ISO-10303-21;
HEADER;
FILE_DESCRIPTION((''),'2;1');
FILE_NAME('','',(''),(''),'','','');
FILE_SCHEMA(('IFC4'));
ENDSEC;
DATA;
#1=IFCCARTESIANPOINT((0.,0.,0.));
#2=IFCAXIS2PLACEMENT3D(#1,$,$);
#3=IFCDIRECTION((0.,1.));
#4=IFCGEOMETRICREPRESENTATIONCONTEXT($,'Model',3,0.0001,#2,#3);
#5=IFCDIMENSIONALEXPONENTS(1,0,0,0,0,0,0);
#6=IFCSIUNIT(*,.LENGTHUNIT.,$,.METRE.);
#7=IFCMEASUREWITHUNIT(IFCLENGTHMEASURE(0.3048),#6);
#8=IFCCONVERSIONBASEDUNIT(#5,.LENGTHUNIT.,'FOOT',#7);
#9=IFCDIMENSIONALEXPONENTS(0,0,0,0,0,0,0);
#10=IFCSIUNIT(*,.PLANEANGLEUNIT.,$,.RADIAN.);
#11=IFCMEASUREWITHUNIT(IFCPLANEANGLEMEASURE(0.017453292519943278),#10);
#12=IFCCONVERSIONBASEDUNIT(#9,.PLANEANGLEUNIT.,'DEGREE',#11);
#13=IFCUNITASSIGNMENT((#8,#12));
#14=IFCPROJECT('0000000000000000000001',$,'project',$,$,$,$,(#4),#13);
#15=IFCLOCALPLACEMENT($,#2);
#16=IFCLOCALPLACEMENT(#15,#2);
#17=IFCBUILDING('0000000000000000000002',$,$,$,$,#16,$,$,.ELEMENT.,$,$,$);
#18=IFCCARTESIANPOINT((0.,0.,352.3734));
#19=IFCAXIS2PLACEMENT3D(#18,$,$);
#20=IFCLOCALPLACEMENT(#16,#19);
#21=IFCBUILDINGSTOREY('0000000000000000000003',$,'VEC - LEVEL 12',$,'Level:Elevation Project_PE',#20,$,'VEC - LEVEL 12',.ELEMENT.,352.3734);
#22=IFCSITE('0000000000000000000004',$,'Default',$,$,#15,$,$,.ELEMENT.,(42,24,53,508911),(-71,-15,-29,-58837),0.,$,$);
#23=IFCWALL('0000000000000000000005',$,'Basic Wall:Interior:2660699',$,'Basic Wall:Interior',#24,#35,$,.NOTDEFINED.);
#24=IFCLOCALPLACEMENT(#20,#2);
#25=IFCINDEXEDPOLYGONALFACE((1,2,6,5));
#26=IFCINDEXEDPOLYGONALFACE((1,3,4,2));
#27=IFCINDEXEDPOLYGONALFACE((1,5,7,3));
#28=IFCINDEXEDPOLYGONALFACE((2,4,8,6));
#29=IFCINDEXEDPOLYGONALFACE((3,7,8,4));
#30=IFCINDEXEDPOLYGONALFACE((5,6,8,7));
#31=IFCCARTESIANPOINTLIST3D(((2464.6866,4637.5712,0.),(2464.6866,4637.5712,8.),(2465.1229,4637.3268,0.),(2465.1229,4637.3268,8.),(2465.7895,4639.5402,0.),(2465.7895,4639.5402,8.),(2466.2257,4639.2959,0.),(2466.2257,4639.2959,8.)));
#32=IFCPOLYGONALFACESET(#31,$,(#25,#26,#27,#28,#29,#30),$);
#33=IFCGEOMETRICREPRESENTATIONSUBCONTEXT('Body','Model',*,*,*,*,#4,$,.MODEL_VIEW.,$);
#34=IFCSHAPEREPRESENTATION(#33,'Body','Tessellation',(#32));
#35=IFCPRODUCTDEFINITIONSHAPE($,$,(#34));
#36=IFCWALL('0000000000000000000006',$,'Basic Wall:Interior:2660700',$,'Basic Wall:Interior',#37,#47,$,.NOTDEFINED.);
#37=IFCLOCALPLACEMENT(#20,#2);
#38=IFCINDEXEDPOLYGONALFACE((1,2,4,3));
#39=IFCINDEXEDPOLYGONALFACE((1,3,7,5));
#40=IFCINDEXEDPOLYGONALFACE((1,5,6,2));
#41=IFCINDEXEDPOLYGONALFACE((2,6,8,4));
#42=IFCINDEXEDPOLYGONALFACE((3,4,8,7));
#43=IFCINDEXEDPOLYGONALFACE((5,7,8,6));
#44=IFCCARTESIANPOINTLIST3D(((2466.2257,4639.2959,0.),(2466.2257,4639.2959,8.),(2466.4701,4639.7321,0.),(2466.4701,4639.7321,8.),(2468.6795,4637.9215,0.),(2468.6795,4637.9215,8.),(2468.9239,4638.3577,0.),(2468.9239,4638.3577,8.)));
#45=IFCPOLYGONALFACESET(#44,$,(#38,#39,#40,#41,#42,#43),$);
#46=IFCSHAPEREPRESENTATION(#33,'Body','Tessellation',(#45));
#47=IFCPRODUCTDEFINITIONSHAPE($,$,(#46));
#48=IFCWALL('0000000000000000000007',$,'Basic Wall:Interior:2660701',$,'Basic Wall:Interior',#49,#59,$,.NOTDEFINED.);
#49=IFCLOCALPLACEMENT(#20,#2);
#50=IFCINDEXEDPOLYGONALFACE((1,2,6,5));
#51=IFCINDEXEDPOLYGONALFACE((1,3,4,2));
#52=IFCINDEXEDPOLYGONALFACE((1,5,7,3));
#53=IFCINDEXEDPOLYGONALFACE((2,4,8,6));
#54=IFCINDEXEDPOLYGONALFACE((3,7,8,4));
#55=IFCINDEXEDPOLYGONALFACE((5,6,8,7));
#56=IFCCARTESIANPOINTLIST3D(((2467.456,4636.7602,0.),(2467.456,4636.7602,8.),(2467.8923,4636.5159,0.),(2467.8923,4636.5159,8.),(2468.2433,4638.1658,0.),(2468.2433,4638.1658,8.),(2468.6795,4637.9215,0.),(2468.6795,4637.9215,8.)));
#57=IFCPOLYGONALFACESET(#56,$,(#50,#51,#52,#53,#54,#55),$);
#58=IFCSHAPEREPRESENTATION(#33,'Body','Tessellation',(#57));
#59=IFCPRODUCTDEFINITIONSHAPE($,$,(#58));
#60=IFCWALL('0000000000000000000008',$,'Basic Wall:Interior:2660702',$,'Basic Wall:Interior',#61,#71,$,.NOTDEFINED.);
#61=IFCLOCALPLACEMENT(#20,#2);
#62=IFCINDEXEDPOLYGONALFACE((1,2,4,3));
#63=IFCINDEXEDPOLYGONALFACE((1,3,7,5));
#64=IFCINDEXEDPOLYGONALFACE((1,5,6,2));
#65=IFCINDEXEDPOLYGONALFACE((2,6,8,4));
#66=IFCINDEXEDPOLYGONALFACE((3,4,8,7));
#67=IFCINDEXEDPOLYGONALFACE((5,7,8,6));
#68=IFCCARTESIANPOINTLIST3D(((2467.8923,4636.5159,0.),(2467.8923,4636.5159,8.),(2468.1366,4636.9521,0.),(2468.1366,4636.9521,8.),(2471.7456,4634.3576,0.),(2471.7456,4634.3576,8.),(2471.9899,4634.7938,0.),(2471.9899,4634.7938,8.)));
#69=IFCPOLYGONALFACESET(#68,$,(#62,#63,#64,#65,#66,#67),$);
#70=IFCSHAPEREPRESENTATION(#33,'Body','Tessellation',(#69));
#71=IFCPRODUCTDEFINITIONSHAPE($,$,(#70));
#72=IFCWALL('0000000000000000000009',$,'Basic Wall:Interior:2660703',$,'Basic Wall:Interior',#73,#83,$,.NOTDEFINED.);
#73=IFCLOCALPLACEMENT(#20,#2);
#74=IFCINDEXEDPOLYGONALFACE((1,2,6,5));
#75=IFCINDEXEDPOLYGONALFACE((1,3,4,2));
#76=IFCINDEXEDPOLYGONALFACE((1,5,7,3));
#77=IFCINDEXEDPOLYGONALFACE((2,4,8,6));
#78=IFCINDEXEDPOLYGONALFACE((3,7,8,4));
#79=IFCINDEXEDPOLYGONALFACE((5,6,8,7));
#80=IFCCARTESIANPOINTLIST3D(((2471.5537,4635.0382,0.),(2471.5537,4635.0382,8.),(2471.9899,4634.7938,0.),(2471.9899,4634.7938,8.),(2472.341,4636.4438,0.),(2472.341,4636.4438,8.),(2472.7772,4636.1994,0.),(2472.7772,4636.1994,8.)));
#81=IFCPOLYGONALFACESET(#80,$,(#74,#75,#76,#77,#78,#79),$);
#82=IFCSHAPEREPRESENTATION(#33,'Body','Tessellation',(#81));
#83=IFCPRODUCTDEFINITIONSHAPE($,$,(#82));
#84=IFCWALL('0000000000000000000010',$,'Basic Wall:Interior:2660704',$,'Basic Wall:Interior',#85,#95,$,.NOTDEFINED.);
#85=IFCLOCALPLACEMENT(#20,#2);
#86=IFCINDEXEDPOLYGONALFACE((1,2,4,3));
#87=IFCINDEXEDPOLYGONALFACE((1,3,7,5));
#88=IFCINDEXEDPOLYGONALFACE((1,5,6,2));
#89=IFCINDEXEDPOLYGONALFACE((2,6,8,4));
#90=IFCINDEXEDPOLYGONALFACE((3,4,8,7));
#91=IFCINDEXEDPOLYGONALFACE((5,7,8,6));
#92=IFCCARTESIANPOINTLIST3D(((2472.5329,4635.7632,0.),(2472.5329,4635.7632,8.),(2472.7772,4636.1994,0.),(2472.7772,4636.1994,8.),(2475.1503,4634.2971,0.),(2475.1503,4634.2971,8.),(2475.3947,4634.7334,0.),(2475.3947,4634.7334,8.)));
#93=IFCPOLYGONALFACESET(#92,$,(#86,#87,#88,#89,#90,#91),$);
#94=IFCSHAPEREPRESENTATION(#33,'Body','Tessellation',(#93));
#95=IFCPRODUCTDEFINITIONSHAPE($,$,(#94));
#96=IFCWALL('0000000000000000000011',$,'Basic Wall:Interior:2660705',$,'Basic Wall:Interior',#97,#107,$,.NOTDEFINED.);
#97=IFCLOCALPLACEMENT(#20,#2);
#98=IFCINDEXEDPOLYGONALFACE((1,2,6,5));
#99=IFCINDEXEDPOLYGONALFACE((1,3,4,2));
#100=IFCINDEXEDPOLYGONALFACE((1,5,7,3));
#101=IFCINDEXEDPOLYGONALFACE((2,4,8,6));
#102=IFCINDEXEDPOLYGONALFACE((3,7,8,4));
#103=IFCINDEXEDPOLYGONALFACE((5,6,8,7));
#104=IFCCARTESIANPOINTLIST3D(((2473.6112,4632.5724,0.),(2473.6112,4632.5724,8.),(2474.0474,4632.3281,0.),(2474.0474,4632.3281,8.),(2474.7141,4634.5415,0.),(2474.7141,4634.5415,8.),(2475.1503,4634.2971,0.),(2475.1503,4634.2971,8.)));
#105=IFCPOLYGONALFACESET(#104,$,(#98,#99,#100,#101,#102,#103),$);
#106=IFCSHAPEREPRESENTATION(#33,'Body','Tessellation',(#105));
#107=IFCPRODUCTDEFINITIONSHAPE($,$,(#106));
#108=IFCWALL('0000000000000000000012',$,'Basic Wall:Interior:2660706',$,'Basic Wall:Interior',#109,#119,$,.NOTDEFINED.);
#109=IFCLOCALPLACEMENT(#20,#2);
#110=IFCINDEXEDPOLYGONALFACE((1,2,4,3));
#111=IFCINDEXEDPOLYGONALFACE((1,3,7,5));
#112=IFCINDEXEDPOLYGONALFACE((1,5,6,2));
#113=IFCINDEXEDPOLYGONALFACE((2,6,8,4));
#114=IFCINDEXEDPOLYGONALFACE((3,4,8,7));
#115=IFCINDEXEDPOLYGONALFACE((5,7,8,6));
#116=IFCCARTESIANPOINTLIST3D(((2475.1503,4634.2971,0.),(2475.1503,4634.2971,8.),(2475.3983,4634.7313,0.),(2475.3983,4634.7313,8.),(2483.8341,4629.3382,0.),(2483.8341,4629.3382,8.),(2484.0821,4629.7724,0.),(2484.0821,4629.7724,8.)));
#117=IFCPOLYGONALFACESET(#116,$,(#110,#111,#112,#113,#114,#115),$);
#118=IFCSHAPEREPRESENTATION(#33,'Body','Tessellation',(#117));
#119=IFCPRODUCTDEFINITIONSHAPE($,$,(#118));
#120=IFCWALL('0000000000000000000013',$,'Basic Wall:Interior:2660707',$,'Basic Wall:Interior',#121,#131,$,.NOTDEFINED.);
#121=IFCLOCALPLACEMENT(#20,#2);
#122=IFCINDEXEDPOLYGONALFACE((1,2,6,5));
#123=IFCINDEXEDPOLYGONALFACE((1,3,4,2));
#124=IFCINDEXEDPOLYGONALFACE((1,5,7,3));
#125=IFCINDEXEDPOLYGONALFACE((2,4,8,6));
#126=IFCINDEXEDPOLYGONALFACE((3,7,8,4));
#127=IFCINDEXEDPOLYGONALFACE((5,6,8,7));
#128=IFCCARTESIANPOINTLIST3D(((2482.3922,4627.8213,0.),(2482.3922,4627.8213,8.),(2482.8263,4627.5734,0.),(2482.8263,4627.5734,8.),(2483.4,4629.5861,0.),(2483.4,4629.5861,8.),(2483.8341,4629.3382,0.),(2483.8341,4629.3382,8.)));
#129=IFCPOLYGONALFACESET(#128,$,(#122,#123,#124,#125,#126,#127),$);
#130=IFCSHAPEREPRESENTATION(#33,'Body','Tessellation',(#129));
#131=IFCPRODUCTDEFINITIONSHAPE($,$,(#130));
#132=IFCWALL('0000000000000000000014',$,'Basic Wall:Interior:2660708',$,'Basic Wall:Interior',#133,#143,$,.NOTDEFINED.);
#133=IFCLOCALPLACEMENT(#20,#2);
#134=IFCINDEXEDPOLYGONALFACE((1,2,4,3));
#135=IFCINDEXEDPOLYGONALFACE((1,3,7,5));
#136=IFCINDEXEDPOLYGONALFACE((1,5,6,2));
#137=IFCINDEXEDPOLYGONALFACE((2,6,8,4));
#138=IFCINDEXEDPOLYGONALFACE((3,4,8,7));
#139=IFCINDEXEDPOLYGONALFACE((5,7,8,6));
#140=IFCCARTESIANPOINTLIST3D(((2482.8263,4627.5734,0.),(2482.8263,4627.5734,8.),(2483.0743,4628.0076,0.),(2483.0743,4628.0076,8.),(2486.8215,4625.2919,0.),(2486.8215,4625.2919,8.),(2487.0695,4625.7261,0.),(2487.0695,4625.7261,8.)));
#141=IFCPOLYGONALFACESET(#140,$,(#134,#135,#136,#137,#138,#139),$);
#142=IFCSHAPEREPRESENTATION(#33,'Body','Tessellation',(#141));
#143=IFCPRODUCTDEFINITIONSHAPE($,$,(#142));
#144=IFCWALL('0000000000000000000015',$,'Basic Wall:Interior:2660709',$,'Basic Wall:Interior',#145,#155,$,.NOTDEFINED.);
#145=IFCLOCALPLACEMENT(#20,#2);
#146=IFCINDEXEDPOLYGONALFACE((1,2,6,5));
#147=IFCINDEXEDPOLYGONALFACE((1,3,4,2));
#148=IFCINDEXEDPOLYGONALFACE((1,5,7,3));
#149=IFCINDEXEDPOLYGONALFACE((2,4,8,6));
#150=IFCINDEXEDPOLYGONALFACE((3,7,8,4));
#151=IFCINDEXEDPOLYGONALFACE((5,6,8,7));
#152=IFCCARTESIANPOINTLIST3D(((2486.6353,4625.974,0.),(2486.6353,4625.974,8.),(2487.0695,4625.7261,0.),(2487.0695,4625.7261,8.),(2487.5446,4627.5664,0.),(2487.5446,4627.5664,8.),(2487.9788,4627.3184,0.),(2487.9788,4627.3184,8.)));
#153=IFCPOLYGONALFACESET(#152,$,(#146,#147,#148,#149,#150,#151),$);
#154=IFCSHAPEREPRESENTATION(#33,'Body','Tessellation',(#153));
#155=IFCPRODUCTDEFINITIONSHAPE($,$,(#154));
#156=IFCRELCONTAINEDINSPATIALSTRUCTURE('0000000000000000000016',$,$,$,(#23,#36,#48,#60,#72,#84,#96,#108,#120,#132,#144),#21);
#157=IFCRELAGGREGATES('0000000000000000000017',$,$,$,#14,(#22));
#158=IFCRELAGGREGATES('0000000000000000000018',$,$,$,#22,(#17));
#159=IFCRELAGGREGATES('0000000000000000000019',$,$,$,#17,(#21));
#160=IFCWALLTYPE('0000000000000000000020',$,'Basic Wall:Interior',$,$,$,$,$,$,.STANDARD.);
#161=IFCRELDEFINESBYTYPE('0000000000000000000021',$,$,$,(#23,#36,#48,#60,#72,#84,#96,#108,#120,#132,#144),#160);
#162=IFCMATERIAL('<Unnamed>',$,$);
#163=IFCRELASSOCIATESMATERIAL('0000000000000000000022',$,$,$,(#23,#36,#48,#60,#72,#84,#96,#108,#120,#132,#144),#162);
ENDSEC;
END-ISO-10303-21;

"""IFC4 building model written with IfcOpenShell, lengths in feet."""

from ifc_helpers import new_model, entity, si_unit, converted_unit, direction, frame, origin, place, context, subcontext, project, spatial, indexed_curve, outline, extrude, material, type_object, element, save


model = new_model("IFC4")

# Units and contexts
model_context = context("Model", 3, precision=0.0001, world=origin(), true_north=direction((0.0, 1.0)))
body_context = subcontext(model_context, "Body", "Model", "MODEL_VIEW")
ifc_project = project(units=[converted_unit("LENGTHUNIT", "FOOT", entity("IfcLengthMeasure", 0.3048), si_unit("LENGTHUNIT", "METRE"), dimensions=[1, 0, 0, 0, 0, 0, 0]), converted_unit("PLANEANGLEUNIT", "DEGREE", entity("IfcPlaneAngleMeasure", 0.017453292519943278), si_unit("PLANEANGLEUNIT", "RADIAN"), dimensions=[0, 0, 0, 0, 0, 0, 0])], contexts=[model_context])

# Site, building, storey
site_placement = place(None, origin())
site = spatial("IfcSite", under=ifc_project, at=site_placement, Name="Default", CompositionType="ELEMENT", RefLatitude=(42, 24, 53, 508911), RefLongitude=(-71, -15, -29, -58837), RefElevation=0.0)
building_placement = place(site_placement, origin())
building = spatial("IfcBuilding", under=site, at=building_placement, CompositionType="ELEMENT")
storey_placement = place(building_placement, frame((0.0, 0.0, 352.3734)))
storey = spatial("IfcBuildingStorey", under=building, at=storey_placement, Name="VEC - LEVEL 12", ObjectType="Level:Elevation Project_PE", LongName="VEC - LEVEL 12", CompositionType="ELEMENT", Elevation=352.3734)

# Walls
ifc_material_1 = material(Name="<Unnamed>")
wall_type = type_object("IfcWallType", Name="Basic Wall:Interior", PredefinedType="STANDARD")
wall_1_placement = place(storey_placement, frame((2466.0076, 4639.418, 0.0), z_axis=(0.0, 0.0, 1.0), x_axis=(-0.488675, -0.872466, 0.0)))
element("IfcWall", 1, at=wall_1_placement, inside=storey, type_object=wall_type, material=ifc_material_1, Name="Basic Wall:Interior:2660699", ObjectType="Basic Wall:Interior", PredefinedType="NOTDEFINED", context=body_context, shape_type="SweptSolid", body=[
    extrude(outline(indexed_curve([(2.2569, 0.25), (0.0, 0.25), (0.0, -0.25), (2.2569, -0.25), (2.2569, 0.25)], self_intersect=False)), origin(), (0.0, 0.0, 1.0), 8.0),
])
wall_2_placement = place(storey_placement, frame((2466.3479, 4639.514, 0.0), z_axis=(0.0, 0.0, 1.0), x_axis=(0.872466, -0.488675, 0.0)))
element("IfcWall", 2, at=wall_2_placement, inside=storey, type_object=wall_type, material=ifc_material_1, Name="Basic Wall:Interior:2660700", ObjectType="Basic Wall:Interior", PredefinedType="NOTDEFINED", context=body_context, shape_type="SweptSolid", body=[
    extrude(outline(indexed_curve([(2.8125, 0.25), (0.0, 0.25), (0.0, -0.25), (2.8125, -0.25), (2.8125, 0.25)], self_intersect=False)), origin(), (0.0, 0.0, 1.0), 8.0),
])
wall_3_placement = place(storey_placement, frame((2468.4614, 4638.0436, 0.0), z_axis=(0.0, 0.0, 1.0), x_axis=(-0.488675, -0.872466, 0.0)))
element("IfcWall", 3, at=wall_3_placement, inside=storey, type_object=wall_type, material=ifc_material_1, Name="Basic Wall:Interior:2660701", ObjectType="Basic Wall:Interior", PredefinedType="NOTDEFINED", context=body_context, shape_type="SweptSolid", body=[
    extrude(outline(indexed_curve([(1.611, 0.25), (0.0, 0.25), (0.0, -0.25), (1.611, -0.25), (1.611, 0.25)], self_intersect=False)), origin(), (0.0, 0.0, 1.0), 8.0),
])
wall_4_placement = place(storey_placement, frame((2468.0144, 4636.734, 0.0), z_axis=(0.0, 0.0, 1.0), x_axis=(0.872466, -0.488675, 0.0)))
element("IfcWall", 4, at=wall_4_placement, inside=storey, type_object=wall_type, material=ifc_material_1, Name="Basic Wall:Interior:2660702", ObjectType="Basic Wall:Interior", PredefinedType="NOTDEFINED", context=body_context, shape_type="SweptSolid", body=[
    extrude(outline(indexed_curve([(4.4166, 0.25), (0.0, 0.25), (0.0, -0.25), (4.4166, -0.25), (4.4166, 0.25)], self_intersect=False)), origin(), (0.0, 0.0, 1.0), 8.0),
])
wall_5_placement = place(storey_placement, frame((2471.7718, 4634.916, 0.0), z_axis=(0.0, 0.0, 1.0), x_axis=(0.488675, 0.872466, 0.0)))
element("IfcWall", 5, at=wall_5_placement, inside=storey, type_object=wall_type, material=ifc_material_1, Name="Basic Wall:Interior:2660703", ObjectType="Basic Wall:Interior", PredefinedType="NOTDEFINED", context=body_context, shape_type="SweptSolid", body=[
    extrude(outline(indexed_curve([(1.611, 0.25), (0.0, 0.25), (0.0, -0.25), (1.611, -0.25), (1.611, 0.25)], self_intersect=False)), origin(), (0.0, 0.0, 1.0), 8.0),
])
wall_6_placement = place(storey_placement, frame((2472.655, 4635.9813, 0.0), z_axis=(0.0, 0.0, 1.0), x_axis=(0.872466, -0.488675, 0.0)))
element("IfcWall", 6, at=wall_6_placement, inside=storey, type_object=wall_type, material=ifc_material_1, Name="Basic Wall:Interior:2660704", ObjectType="Basic Wall:Interior", PredefinedType="NOTDEFINED", context=body_context, shape_type="SweptSolid", body=[
    extrude(outline(indexed_curve([(3.0001, 0.25), (0.0, 0.25), (0.0, -0.25), (3.0001, -0.25), (3.0001, 0.25)], self_intersect=False)), origin(), (0.0, 0.0, 1.0), 8.0),
])
wall_7_placement = place(storey_placement, frame((2474.9322, 4634.4193, 0.0), z_axis=(0.0, 0.0, 1.0), x_axis=(-0.488675, -0.872466, 0.0)))
element("IfcWall", 7, at=wall_7_placement, inside=storey, type_object=wall_type, material=ifc_material_1, Name="Basic Wall:Interior:2660705", ObjectType="Basic Wall:Interior", PredefinedType="NOTDEFINED", context=body_context, shape_type="SweptSolid", body=[
    extrude(outline(indexed_curve([(2.2569, 0.25), (0.0, 0.25), (0.0, -0.25), (2.2569, -0.25), (2.2569, 0.25)], self_intersect=False)), origin(), (0.0, 0.0, 1.0), 8.0),
])
wall_8_placement = place(storey_placement, frame((2475.2743, 4634.5142, 0.0), z_axis=(0.0, 0.0, 1.0), x_axis=(0.868382, -0.495895, 0.0)))
element("IfcWall", 8, at=wall_8_placement, inside=storey, type_object=wall_type, material=ifc_material_1, Name="Basic Wall:Interior:2660706", ObjectType="Basic Wall:Interior", PredefinedType="NOTDEFINED", context=body_context, shape_type="SweptSolid", body=[
    extrude(outline(indexed_curve([(10.0, 0.25), (0.0, 0.25), (0.0, -0.25), (10.0, -0.25), (10.0, 0.25)], self_intersect=False)), origin(), (0.0, 0.0, 1.0), 8.0),
])
wall_9_placement = place(storey_placement, frame((2483.617, 4629.4622, 0.0), z_axis=(0.0, 0.0, 1.0), x_axis=(-0.495895, -0.868382, 0.0)))
element("IfcWall", 9, at=wall_9_placement, inside=storey, type_object=wall_type, material=ifc_material_1, Name="Basic Wall:Interior:2660707", ObjectType="Basic Wall:Interior", PredefinedType="NOTDEFINED", context=body_context, shape_type="SweptSolid", body=[
    extrude(outline(indexed_curve([(2.0323, 0.25), (0.0, 0.25), (0.0, -0.25), (2.0323, -0.25), (2.0323, 0.25)], self_intersect=False)), origin(), (0.0, 0.0, 1.0), 8.0),
])
wall_10_placement = place(storey_placement, frame((2482.9503, 4627.7905, 0.0), z_axis=(0.0, 0.0, 1.0), x_axis=(0.868382, -0.495895, 0.0)))
element("IfcWall", 10, at=wall_10_placement, inside=storey, type_object=wall_type, material=ifc_material_1, Name="Basic Wall:Interior:2660708", ObjectType="Basic Wall:Interior", PredefinedType="NOTDEFINED", context=body_context, shape_type="SweptSolid", body=[
    extrude(outline(indexed_curve([(4.6007, 0.25), (0.0, 0.25), (0.0, -0.25), (4.6007, -0.25), (4.6007, 0.25)], self_intersect=False)), origin(), (0.0, 0.0, 1.0), 8.0),
])
wall_11_placement = place(storey_placement, frame((2486.8524, 4625.8501, 0.0), z_axis=(0.0, 0.0, 1.0), x_axis=(0.495895, 0.868382, 0.0)))
element("IfcWall", 11, at=wall_11_placement, inside=storey, type_object=wall_type, material=ifc_material_1, Name="Basic Wall:Interior:2660709", ObjectType="Basic Wall:Interior", PredefinedType="NOTDEFINED", context=body_context, shape_type="SweptSolid", body=[
    extrude(outline(indexed_curve([(1.8337, 0.25), (0.0, 0.25), (0.0, -0.25), (1.8337, -0.25), (1.8337, 0.25)], self_intersect=False)), origin(), (0.0, 0.0, 1.0), 8.0),
])

save(model, "model.ifc")
